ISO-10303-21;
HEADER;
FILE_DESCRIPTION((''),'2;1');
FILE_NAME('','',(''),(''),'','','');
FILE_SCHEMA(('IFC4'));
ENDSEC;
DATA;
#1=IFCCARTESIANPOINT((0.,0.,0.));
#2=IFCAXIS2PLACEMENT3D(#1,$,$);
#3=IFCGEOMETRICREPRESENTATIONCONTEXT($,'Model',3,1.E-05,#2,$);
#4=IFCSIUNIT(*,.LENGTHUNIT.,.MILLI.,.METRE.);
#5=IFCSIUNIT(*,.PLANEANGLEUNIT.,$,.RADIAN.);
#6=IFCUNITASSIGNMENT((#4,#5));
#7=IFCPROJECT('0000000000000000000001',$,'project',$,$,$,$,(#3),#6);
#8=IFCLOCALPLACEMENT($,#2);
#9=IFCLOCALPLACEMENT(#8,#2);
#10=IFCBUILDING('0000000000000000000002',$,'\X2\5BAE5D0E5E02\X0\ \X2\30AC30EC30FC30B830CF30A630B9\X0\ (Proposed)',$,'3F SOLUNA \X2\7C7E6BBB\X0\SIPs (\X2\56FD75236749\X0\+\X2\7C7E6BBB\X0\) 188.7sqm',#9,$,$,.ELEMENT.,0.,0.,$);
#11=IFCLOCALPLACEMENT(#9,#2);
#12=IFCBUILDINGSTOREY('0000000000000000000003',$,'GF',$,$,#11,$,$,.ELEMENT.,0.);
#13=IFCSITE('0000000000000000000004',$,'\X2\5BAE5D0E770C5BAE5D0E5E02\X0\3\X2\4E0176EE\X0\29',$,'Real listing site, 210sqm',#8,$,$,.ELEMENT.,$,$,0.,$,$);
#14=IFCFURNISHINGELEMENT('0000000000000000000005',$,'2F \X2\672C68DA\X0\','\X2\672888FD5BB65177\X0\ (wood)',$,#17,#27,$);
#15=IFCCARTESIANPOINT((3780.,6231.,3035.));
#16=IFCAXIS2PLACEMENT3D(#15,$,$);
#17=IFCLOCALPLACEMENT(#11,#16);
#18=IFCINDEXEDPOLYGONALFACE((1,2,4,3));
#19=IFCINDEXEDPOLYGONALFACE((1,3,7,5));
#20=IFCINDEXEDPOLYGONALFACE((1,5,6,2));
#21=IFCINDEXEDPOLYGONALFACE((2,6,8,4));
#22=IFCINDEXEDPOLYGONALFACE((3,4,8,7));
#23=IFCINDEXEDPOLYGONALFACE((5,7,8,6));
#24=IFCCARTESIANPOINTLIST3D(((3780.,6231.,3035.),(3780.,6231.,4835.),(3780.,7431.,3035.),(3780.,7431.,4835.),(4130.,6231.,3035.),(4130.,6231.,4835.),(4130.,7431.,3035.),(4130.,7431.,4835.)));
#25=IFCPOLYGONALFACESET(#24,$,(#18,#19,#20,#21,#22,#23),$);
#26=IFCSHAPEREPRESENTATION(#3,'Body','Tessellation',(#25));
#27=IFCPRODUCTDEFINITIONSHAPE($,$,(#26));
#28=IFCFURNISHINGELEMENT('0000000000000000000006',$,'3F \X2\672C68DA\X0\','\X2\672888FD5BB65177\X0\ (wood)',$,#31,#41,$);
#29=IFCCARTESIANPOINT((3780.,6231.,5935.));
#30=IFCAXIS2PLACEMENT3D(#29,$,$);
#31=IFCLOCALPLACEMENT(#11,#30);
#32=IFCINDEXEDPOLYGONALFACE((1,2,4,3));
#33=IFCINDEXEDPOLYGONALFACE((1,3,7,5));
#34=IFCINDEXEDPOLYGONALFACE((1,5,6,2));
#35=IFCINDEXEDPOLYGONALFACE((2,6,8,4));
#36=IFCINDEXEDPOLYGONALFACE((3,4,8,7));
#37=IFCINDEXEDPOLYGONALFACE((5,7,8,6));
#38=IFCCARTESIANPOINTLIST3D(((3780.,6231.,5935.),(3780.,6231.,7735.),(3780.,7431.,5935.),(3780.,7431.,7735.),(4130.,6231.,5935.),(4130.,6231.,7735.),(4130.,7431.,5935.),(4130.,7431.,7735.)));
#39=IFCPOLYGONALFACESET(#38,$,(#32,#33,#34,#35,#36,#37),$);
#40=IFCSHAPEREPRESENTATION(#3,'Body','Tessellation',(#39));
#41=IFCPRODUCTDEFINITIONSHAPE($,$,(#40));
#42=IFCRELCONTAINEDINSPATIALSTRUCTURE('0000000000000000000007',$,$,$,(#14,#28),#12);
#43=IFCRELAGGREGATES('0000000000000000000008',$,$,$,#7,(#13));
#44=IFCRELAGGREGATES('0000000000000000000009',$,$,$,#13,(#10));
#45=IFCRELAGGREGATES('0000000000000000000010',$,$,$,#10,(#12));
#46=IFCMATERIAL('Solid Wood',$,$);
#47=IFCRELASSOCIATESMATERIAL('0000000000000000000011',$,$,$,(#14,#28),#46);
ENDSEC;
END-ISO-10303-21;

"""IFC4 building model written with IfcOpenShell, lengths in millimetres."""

from ifc_helpers import new_model, si_unit, frame, frame_2d, origin, place, context, project, spatial, rectangle, extrude, material, element, save


model = new_model("IFC4")

# Units and contexts
model_context = context("Model", 3, precision=1e-05, world=origin())
ifc_project = project(units=[si_unit("LENGTHUNIT", "METRE", prefix="MILLI"), si_unit("PLANEANGLEUNIT", "RADIAN")], contexts=[model_context])

# Site, building, storey
site_placement = place(None, origin())
site = spatial("IfcSite", under=ifc_project, at=site_placement, Name="宮崎県宮崎市3丁目29", ObjectType="Real listing site, 210sqm", CompositionType="ELEMENT", RefElevation=0.0)
building_placement = place(site_placement, origin())
building = spatial("IfcBuilding", under=site, at=building_placement, Name="宮崎市 ガレージハウス (Proposed)", ObjectType="3F SOLUNA 籾殻SIPs (国産杉+籾殻) 188.7sqm", CompositionType="ELEMENT", ElevationOfRefHeight=0.0, ElevationOfTerrain=0.0)
storey_placement = place(building_placement, origin())
storey = spatial("IfcBuildingStorey", under=building, at=storey_placement, Name="GF", CompositionType="ELEMENT", Elevation=0.0)

# Shared definitions
ifc_material_1 = material(Name="Solid Wood")

# Furnishing elements
furnishing_1_placement = place(storey_placement, frame((3780.0, 6231.0, 3035.0)))
element("IfcFurnishingElement", 1, at=furnishing_1_placement, inside=storey, material=ifc_material_1, Name="2F 本棚", Description="木製家具 (wood)", context=model_context, shape_type="SweptSolid", body=[
    extrude(rectangle(XDim=350.0, YDim=1200.0, at=frame_2d((175.0, 600.0))), frame((3780.0, 6231.0, 3035.0)), (0.0, 0.0, 1.0), 1800.0),
])
furnishing_2_placement = place(storey_placement, frame((3780.0, 6231.0, 5935.0)))
element("IfcFurnishingElement", 2, at=furnishing_2_placement, inside=storey, material=ifc_material_1, Name="3F 本棚", Description="木製家具 (wood)", context=model_context, shape_type="SweptSolid", body=[
    extrude(rectangle(XDim=350.0, YDim=1200.0, at=frame_2d((175.0, 600.0))), frame((3780.0, 6231.0, 5935.0)), (0.0, 0.0, 1.0), 1800.0),
])

save(model, "model.ifc")
